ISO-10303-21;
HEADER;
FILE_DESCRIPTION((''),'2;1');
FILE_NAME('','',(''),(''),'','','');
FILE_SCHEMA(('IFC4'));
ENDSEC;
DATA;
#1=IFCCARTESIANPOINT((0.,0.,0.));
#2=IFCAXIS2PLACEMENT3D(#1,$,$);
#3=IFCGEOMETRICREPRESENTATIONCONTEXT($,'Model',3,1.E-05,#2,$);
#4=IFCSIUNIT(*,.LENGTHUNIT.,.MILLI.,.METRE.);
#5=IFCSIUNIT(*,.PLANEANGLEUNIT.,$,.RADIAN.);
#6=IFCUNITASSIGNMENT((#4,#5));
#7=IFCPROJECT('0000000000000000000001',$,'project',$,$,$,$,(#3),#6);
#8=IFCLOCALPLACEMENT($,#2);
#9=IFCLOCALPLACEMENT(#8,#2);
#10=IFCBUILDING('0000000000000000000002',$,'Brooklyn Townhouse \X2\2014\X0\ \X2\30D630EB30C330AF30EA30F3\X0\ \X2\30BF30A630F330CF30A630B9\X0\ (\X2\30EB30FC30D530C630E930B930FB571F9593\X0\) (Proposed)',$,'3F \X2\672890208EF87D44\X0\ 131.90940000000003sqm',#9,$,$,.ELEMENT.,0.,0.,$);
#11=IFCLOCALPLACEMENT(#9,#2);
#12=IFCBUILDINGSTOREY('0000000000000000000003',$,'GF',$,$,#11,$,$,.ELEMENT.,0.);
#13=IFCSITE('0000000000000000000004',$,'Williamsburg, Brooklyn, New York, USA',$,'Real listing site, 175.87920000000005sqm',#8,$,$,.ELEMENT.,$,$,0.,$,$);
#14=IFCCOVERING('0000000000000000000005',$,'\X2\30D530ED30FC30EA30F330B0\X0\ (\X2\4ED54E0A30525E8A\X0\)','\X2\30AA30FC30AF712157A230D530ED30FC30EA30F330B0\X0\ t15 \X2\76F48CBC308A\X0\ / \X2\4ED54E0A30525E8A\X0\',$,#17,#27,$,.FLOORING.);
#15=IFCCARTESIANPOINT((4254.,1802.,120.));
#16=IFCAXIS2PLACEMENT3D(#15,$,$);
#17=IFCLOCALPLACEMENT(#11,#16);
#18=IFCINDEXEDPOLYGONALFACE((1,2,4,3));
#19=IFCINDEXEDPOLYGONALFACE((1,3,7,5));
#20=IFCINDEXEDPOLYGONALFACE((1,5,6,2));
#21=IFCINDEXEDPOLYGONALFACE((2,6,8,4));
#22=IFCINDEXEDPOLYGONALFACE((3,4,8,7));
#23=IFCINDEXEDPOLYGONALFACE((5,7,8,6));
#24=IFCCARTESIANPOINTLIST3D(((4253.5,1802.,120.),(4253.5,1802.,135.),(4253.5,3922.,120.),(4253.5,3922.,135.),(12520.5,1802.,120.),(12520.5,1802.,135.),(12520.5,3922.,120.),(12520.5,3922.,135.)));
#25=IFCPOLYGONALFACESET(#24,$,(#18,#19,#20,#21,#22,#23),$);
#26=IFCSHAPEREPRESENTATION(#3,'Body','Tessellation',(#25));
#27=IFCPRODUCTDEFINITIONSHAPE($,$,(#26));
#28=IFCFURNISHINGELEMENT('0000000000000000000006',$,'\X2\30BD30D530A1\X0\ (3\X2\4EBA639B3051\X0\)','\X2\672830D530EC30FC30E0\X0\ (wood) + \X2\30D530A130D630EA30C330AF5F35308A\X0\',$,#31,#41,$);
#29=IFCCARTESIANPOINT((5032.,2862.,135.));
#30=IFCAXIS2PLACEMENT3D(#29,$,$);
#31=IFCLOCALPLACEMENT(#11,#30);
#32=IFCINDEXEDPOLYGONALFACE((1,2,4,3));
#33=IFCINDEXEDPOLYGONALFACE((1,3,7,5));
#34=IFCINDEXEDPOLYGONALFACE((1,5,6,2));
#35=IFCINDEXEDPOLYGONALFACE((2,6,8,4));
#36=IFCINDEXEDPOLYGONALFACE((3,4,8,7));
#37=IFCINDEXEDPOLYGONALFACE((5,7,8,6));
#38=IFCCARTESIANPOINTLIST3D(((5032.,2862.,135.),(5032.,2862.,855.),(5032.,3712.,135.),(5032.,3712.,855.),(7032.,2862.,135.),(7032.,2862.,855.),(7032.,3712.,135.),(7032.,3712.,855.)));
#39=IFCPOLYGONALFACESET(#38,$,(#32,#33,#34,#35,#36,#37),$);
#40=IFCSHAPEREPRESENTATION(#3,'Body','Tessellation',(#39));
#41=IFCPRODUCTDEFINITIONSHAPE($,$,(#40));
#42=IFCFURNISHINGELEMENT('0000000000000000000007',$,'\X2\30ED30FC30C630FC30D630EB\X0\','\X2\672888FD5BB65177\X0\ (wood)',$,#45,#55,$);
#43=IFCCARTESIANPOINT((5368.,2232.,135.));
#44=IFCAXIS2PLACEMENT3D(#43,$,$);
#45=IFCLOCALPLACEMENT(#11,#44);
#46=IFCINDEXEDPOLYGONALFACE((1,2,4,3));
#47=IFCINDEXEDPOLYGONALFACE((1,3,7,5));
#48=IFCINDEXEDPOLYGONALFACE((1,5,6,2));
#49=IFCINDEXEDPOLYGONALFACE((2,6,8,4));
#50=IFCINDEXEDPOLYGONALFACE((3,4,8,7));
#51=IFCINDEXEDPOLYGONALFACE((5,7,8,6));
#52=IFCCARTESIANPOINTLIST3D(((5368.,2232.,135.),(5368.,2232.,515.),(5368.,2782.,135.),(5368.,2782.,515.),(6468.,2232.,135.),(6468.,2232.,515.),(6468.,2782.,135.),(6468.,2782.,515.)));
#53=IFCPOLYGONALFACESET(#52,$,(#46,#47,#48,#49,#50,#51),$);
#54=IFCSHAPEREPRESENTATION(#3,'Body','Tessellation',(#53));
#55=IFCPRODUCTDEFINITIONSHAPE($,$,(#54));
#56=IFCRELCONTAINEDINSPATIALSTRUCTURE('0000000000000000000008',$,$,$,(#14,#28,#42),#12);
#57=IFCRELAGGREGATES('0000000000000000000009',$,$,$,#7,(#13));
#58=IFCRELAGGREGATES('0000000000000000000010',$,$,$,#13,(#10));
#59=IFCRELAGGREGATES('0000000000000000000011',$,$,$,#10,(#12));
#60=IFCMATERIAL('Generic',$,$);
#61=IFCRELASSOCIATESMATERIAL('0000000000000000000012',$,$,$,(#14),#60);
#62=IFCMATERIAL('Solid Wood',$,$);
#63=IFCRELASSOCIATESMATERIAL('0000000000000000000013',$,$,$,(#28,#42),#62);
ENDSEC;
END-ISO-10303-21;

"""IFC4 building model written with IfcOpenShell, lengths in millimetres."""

from ifc_helpers import new_model, si_unit, frame, frame_2d, origin, place, context, project, spatial, rectangle, extrude, material, element, save


model = new_model("IFC4")

# Units and contexts
model_context = context("Model", 3, precision=1e-05, world=origin())
ifc_project = project(units=[si_unit("LENGTHUNIT", "METRE", prefix="MILLI"), si_unit("PLANEANGLEUNIT", "RADIAN")], contexts=[model_context])

# Site, building, storey
site_placement = place(None, origin())
site = spatial("IfcSite", under=ifc_project, at=site_placement, Name="Williamsburg, Brooklyn, New York, USA", ObjectType="Real listing site, 175.87920000000005sqm", CompositionType="ELEMENT", RefElevation=0.0)
building_placement = place(site_placement, origin())
building = spatial("IfcBuilding", under=site, at=building_placement, Name="Brooklyn Townhouse — ブルックリン タウンハウス (ルーフテラス・土間) (Proposed)", ObjectType="3F 木造軸組 131.90940000000003sqm", CompositionType="ELEMENT", ElevationOfRefHeight=0.0, ElevationOfTerrain=0.0)
storey_placement = place(building_placement, origin())
storey = spatial("IfcBuildingStorey", under=building, at=storey_placement, Name="GF", CompositionType="ELEMENT", Elevation=0.0)

# Shared definitions
ifc_material_1 = material(Name="Solid Wood")

# Covering
ifc_material_2 = material(Name="Generic")
covering_placement = place(storey_placement, frame((4254.0, 1802.0, 120.0)))
element("IfcCovering", 1, at=covering_placement, inside=storey, material=ifc_material_2, Name="フローリング (仕上げ床)", Description="オーク無垢フローリング t15 直貼り / 仕上げ床", PredefinedType="FLOORING", context=model_context, shape_type="SweptSolid", body=[
    extrude(rectangle(XDim=8267.0, YDim=2120.0, at=frame_2d((4133.0, 1060.0))), frame((4254.0, 1802.0, 120.0)), (0.0, 0.0, 1.0), 15.0),
])

# Furnishing elements
furnishing_1_placement = place(storey_placement, frame((5032.0, 2862.0, 135.0)))
element("IfcFurnishingElement", 2, at=furnishing_1_placement, inside=storey, material=ifc_material_1, Name="ソファ (3人掛け)", Description="木フレーム (wood) + ファブリック張り", context=model_context, shape_type="SweptSolid", body=[
    extrude(rectangle(XDim=2000.0, YDim=850.0, at=frame_2d((1000.0, 425.0))), frame((5032.0, 2862.0, 135.0)), (0.0, 0.0, 1.0), 720.0),
])
furnishing_2_placement = place(storey_placement, frame((5368.0, 2232.0, 135.0)))
element("IfcFurnishingElement", 3, at=furnishing_2_placement, inside=storey, material=ifc_material_1, Name="ローテーブル", Description="木製家具 (wood)", context=model_context, shape_type="SweptSolid", body=[
    extrude(rectangle(XDim=1100.0, YDim=550.0, at=frame_2d((550.0, 275.0))), frame((5368.0, 2232.0, 135.0)), (0.0, 0.0, 1.0), 380.0),
])

save(model, "model.ifc")
